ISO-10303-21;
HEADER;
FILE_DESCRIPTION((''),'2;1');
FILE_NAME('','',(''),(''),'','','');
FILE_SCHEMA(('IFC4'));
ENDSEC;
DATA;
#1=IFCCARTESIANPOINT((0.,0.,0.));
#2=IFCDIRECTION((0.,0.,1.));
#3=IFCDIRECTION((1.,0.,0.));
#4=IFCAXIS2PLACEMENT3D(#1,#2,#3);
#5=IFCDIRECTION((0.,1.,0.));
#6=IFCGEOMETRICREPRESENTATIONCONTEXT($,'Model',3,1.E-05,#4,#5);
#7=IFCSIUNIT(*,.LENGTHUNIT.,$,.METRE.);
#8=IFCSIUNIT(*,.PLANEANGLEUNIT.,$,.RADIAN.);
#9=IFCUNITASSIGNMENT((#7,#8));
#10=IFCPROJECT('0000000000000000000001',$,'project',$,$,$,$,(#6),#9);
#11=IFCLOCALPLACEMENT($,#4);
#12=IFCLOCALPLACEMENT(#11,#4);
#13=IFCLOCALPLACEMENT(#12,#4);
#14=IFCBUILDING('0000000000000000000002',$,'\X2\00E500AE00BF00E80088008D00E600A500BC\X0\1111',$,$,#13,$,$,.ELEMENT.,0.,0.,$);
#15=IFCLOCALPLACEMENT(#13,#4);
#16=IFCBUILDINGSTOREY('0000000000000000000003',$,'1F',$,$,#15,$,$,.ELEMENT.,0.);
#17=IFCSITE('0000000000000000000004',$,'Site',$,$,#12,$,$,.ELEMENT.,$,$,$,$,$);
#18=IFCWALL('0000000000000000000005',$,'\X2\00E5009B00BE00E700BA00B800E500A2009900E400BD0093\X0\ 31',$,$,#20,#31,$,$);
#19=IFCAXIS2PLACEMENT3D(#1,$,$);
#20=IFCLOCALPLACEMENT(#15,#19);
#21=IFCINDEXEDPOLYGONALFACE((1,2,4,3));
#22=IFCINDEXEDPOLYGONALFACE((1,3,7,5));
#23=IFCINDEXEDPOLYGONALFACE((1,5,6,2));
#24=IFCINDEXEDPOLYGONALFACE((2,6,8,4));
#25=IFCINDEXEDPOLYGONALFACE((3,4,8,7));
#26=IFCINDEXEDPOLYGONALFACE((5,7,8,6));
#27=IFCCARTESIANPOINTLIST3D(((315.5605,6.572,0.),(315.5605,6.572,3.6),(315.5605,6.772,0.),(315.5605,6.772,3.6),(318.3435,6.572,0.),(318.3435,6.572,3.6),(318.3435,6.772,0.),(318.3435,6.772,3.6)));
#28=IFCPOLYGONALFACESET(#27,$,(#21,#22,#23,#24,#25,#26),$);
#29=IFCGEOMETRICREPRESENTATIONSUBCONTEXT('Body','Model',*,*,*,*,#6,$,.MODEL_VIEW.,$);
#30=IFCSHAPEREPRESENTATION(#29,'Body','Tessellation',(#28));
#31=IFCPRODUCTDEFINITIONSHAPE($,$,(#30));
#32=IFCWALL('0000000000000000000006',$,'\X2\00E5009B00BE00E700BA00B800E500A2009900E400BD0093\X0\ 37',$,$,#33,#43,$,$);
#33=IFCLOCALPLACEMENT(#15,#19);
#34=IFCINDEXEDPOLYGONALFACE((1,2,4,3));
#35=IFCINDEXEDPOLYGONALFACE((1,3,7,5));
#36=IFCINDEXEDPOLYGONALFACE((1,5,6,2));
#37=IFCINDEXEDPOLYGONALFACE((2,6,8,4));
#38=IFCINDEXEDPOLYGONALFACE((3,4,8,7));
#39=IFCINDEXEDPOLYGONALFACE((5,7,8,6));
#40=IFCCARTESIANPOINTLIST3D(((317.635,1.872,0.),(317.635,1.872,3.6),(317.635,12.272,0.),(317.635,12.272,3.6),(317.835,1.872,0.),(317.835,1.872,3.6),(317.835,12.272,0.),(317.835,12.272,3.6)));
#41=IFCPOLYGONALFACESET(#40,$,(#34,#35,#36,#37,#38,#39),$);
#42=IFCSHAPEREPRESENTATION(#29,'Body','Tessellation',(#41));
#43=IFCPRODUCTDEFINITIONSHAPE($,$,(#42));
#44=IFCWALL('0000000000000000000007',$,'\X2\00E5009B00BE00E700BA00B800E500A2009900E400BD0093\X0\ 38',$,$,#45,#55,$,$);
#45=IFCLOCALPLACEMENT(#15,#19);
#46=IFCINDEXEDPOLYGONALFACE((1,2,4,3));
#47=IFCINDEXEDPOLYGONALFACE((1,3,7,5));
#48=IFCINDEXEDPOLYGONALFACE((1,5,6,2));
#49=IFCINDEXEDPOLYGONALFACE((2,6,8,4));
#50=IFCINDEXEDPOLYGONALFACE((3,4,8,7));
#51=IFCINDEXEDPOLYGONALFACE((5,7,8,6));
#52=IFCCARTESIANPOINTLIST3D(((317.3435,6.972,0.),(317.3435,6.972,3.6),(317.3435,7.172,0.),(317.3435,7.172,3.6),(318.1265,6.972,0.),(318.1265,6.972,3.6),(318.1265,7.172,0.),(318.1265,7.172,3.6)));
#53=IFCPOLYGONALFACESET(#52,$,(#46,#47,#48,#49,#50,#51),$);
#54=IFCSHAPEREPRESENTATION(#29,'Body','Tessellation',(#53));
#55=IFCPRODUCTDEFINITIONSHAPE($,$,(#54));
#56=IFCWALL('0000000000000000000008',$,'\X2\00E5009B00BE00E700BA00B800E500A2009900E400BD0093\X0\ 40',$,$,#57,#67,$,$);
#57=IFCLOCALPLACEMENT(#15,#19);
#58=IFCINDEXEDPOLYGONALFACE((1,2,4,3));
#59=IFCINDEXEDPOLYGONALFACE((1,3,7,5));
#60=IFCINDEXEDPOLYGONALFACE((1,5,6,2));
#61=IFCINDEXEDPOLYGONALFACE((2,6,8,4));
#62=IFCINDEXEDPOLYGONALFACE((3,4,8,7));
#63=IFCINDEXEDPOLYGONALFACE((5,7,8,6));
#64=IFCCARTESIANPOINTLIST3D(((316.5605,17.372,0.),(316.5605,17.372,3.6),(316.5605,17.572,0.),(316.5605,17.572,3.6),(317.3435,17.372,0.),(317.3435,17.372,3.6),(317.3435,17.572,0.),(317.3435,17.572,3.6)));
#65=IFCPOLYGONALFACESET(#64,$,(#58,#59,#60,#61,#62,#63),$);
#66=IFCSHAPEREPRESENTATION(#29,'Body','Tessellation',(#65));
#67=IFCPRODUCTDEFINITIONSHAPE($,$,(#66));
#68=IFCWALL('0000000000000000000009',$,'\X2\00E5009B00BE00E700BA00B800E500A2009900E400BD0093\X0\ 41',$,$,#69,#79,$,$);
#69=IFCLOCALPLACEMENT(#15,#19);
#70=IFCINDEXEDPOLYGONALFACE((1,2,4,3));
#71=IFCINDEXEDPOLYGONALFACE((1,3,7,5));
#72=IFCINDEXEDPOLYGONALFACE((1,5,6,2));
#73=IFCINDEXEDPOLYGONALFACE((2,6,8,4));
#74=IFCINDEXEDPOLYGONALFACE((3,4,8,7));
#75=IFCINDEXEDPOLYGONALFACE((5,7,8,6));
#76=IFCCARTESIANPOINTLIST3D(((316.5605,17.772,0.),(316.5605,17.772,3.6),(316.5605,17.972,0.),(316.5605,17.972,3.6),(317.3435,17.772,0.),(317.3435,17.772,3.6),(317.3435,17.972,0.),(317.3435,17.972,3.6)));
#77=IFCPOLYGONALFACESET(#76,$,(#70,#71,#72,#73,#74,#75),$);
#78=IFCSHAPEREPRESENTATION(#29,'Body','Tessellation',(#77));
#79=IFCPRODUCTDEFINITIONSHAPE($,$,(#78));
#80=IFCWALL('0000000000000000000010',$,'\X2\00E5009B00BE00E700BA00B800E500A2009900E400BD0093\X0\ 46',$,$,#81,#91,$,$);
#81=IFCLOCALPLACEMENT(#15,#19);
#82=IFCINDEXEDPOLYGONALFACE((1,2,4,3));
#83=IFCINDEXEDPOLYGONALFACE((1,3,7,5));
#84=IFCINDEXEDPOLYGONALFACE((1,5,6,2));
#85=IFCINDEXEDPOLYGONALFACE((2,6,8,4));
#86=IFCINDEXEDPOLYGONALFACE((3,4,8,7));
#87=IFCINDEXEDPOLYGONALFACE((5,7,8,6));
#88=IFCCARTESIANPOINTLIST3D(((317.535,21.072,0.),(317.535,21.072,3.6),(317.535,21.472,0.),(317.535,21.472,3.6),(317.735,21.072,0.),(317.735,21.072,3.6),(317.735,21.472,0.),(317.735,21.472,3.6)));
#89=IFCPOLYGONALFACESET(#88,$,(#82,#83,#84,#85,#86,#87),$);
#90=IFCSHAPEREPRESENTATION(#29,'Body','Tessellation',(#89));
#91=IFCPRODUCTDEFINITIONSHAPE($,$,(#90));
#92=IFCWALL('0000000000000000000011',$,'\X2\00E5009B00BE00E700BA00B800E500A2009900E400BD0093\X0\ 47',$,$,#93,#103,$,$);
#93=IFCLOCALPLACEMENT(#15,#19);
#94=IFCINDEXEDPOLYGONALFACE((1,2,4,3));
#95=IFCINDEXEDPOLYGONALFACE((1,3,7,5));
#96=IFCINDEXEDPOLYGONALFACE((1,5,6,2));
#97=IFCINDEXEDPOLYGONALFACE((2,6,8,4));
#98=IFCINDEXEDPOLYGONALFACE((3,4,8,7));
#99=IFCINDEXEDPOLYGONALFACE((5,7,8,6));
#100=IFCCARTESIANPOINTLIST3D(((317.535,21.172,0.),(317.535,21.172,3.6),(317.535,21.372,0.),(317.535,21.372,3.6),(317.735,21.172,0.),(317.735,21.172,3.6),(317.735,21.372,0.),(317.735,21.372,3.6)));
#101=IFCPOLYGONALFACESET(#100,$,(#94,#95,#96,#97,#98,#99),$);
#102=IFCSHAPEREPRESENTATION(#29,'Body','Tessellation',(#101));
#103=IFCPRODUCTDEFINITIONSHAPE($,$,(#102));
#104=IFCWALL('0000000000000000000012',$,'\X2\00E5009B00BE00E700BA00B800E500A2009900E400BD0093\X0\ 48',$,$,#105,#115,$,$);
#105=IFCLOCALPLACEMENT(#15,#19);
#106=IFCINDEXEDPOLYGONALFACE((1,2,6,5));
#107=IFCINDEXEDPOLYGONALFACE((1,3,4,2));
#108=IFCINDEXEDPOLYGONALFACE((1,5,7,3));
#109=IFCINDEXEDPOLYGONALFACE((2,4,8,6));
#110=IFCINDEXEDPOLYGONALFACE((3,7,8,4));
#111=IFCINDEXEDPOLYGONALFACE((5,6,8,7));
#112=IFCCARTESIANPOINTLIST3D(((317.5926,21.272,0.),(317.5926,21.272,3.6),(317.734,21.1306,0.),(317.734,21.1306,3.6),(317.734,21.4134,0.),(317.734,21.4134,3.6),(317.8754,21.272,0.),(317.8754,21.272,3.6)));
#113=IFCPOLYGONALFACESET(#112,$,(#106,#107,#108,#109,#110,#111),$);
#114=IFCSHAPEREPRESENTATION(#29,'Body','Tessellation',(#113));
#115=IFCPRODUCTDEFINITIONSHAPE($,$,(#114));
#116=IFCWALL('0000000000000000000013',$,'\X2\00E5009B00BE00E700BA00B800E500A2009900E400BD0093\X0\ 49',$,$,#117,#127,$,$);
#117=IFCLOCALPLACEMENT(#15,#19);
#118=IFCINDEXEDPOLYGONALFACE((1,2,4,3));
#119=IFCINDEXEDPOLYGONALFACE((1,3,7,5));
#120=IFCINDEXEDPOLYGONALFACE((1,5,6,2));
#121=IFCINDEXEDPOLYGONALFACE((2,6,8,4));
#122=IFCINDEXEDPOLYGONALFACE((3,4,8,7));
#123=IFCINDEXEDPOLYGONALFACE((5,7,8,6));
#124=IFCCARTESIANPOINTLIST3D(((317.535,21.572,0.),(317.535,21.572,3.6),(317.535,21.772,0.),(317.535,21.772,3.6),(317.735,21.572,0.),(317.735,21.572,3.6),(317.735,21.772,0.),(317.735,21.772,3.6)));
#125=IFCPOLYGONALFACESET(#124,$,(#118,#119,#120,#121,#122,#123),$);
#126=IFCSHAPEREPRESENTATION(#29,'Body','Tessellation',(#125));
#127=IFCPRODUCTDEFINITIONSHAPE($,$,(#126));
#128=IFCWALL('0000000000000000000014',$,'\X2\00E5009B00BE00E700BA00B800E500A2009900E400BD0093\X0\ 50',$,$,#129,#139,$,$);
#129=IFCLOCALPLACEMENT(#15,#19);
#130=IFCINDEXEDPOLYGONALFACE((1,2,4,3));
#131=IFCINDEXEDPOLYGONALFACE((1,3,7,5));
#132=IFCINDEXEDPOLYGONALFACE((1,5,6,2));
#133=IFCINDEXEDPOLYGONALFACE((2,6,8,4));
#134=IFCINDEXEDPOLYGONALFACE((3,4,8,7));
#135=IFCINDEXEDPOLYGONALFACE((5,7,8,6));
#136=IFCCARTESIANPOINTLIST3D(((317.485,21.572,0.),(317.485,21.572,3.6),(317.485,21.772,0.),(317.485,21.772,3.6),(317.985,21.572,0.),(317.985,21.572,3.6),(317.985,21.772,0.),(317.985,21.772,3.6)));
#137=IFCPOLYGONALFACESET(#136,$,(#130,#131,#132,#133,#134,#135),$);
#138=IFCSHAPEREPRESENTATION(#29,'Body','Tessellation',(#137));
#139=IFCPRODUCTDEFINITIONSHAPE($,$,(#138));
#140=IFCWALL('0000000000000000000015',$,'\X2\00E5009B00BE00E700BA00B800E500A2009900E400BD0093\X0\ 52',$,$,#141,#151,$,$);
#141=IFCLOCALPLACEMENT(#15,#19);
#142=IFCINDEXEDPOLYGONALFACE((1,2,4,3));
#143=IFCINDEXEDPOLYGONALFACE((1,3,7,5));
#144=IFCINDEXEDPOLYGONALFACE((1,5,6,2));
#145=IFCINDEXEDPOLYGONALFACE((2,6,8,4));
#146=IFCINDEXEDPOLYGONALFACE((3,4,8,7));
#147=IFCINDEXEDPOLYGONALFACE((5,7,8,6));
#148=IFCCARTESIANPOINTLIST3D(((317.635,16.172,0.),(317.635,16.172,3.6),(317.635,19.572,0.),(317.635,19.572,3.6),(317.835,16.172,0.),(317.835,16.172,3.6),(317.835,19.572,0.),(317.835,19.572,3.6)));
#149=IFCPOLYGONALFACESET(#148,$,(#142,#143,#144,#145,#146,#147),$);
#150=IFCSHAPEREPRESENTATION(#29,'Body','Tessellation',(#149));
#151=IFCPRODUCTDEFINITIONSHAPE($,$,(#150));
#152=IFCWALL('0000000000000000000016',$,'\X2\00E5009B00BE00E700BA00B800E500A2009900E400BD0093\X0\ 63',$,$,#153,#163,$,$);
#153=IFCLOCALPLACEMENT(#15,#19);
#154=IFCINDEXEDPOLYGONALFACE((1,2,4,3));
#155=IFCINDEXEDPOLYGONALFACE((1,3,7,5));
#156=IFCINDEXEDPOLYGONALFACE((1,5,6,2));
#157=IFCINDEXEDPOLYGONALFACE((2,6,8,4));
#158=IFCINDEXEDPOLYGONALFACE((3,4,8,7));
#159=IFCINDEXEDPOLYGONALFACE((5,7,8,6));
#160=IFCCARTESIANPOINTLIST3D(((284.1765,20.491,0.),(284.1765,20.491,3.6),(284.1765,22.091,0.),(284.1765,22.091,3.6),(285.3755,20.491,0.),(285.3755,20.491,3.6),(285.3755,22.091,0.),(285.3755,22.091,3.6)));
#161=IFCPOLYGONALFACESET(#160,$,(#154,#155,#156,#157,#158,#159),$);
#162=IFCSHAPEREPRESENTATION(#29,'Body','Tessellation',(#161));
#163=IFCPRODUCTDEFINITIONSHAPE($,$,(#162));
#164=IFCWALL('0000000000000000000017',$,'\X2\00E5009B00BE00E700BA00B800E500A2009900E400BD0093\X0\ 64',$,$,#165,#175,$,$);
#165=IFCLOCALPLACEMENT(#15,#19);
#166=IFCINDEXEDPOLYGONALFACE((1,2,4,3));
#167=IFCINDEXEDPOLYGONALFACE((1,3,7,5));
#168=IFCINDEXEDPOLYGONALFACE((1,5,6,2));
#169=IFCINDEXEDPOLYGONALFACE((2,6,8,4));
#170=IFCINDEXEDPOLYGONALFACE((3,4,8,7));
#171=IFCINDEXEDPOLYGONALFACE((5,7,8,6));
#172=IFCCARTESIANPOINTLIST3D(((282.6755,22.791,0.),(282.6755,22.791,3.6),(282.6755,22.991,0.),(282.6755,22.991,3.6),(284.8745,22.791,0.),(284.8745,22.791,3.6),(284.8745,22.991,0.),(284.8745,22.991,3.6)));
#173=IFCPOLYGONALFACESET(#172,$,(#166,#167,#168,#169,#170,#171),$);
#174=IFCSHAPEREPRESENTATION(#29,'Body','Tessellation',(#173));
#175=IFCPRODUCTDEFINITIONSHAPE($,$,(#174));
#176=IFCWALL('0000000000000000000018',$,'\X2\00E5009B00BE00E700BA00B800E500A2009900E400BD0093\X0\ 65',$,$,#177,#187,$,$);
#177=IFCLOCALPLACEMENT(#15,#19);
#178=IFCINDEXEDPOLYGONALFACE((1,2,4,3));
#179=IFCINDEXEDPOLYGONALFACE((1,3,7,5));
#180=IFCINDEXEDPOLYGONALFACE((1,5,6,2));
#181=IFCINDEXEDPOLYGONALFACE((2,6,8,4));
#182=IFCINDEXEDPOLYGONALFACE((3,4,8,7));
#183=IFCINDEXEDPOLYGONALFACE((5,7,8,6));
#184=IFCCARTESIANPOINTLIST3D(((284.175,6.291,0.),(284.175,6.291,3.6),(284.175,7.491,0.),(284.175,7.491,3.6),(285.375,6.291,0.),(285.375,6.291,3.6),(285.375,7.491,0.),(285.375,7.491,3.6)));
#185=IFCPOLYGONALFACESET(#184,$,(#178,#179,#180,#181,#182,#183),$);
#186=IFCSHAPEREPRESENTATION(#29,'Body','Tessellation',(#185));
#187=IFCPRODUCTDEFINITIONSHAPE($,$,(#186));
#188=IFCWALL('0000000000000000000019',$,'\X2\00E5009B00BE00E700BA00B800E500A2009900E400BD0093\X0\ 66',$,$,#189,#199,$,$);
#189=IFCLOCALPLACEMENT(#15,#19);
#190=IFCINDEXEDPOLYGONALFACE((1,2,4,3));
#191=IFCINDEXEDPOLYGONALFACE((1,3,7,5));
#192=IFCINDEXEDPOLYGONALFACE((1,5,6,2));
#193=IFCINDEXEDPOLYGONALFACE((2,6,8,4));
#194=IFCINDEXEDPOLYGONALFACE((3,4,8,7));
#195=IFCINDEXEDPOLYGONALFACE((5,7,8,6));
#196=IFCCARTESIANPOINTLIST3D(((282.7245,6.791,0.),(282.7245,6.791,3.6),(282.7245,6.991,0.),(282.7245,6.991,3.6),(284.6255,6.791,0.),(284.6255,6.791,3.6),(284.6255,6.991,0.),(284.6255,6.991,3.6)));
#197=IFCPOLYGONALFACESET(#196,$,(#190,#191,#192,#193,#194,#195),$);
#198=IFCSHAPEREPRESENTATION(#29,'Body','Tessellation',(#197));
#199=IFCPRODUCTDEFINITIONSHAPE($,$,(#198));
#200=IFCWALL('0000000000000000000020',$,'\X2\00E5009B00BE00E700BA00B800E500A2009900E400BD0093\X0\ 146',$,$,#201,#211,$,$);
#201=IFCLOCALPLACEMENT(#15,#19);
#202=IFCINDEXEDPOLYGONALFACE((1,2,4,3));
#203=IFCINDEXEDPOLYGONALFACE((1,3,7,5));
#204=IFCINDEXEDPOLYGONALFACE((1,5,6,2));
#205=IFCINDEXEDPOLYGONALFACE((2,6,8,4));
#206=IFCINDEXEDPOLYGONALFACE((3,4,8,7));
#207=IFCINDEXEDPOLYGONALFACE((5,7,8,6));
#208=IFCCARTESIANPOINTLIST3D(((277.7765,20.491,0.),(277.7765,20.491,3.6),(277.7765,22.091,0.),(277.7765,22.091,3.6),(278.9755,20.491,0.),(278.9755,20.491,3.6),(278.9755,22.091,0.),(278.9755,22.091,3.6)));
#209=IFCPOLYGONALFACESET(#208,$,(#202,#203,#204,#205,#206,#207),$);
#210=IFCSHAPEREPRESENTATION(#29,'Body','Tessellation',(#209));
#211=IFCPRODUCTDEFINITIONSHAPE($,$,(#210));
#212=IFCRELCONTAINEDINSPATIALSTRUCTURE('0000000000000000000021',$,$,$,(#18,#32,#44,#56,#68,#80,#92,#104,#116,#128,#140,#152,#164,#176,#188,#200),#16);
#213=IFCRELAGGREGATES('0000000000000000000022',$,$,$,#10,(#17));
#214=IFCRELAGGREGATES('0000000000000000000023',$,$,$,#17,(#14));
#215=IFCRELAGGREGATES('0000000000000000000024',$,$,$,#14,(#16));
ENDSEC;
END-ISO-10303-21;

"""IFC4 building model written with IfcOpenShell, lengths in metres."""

from ifc_helpers import new_model, si_unit, direction, frame, frame_2d, origin_with_axes, place, context, subcontext, project, spatial, rectangle, extrude, element, save


model = new_model("IFC4")

# Units and contexts
model_context = context("Model", 3, precision=1e-05, world=origin_with_axes(), true_north=direction((0.0, 1.0, 0.0)))
body_context = subcontext(model_context, "Body", "Model", "MODEL_VIEW")
ifc_project = project(units=[si_unit("LENGTHUNIT", "METRE"), si_unit("PLANEANGLEUNIT", "RADIAN")], contexts=[model_context])

# Site, building, storey
placement = place(None, origin_with_axes())
site_placement = place(placement, origin_with_axes())
site = spatial("IfcSite", under=ifc_project, at=site_placement, Name="Site", CompositionType="ELEMENT")
building_placement = place(site_placement, origin_with_axes())
building = spatial("IfcBuilding", under=site, at=building_placement, Name="å®¿è\u0088\u008dæ¥¼1111", CompositionType="ELEMENT", ElevationOfRefHeight=0.0, ElevationOfTerrain=0.0)
storey_placement = place(building_placement, origin_with_axes())
storey = spatial("IfcBuildingStorey", under=building, at=storey_placement, Name="1F", CompositionType="ELEMENT", Elevation=0.0)

# Walls
wall_1_placement = place(storey_placement, frame((316.952, 6.672, 0.0), z_axis=(0.0, 0.0, 1.0), x_axis=(1.0, 0.0, 0.0)))
element("IfcWall", 1, at=wall_1_placement, inside=storey, Name="å\u009b¾çº¸å¢\u0099ä½\u0093 31", context=body_context, shape_type="SweptSolid", body=[
    extrude(rectangle(XDim=2.783, YDim=0.2, at=frame_2d((0.0, 0.0), x_axis=(1.0, 0.0, 0.0))), frame((0.0, 0.0, 0.0), z_axis=(0.0, 0.0, 1.0)), (0.0, 0.0, 1.0), 3.6),
])
wall_2_placement = place(storey_placement, frame((317.735, 7.072, 0.0), z_axis=(0.0, 0.0, 1.0), x_axis=(0.0, 1.0, 0.0)))
element("IfcWall", 2, at=wall_2_placement, inside=storey, Name="å\u009b¾çº¸å¢\u0099ä½\u0093 37", context=body_context, shape_type="SweptSolid", body=[
    extrude(rectangle(XDim=10.4, YDim=0.2, at=frame_2d((0.0, 0.0), x_axis=(1.0, 0.0, 0.0))), frame((0.0, 0.0, 0.0), z_axis=(0.0, 0.0, 1.0)), (0.0, 0.0, 1.0), 3.6),
])
for number, where, z_axis, x_axis, name in (
    (3, (317.735, 7.072, 0.0), (0.0, 0.0, 1.0), (-1.0, 0.0, 0.0), "å\u009b¾çº¸å¢\u0099ä½\u0093 38"),
    (4, (316.952, 17.472, 0.0), (0.0, 0.0, 1.0), (1.0, 0.0, 0.0), "å\u009b¾çº¸å¢\u0099ä½\u0093 40"),
    (5, (316.952, 17.872, 0.0), (0.0, 0.0, 1.0), (1.0, 0.0, 0.0), "å\u009b¾çº¸å¢\u0099ä½\u0093 41"),
):
    element("IfcWall", number, at=place(storey_placement, frame(where, z_axis=z_axis, x_axis=x_axis)), inside=storey, Name=name, context=body_context, shape_type="SweptSolid", body=[
        extrude(rectangle(XDim=0.783, YDim=0.2, at=frame_2d((0.0, 0.0), x_axis=(1.0, 0.0, 0.0))), frame((0.0, 0.0, 0.0), z_axis=(0.0, 0.0, 1.0)), (0.0, 0.0, 1.0), 3.6),
    ])
wall_3_placement = place(storey_placement, frame((317.635, 21.272, 0.0), z_axis=(0.0, 0.0, 1.0), x_axis=(0.0, 1.0, 0.0)))
element("IfcWall", 6, at=wall_3_placement, inside=storey, Name="å\u009b¾çº¸å¢\u0099ä½\u0093 46", context=body_context, shape_type="SweptSolid", body=[
    extrude(rectangle(XDim=0.4, YDim=0.2, at=frame_2d((0.0, 0.0), x_axis=(1.0, 0.0, 0.0))), frame((0.0, 0.0, 0.0), z_axis=(0.0, 0.0, 1.0)), (0.0, 0.0, 1.0), 3.6),
])
for number, where, z_axis, x_axis, name in (
    (7, (317.635, 21.272, 0.0), (0.0, 0.0, 1.0), (1.0, 0.0, 0.0), "å\u009b¾çº¸å¢\u0099ä½\u0093 47"),
    (8, (317.734, 21.272, 0.0), (0.0, 0.0, 1.0), (0.707107, -0.707107, 0.0), "å\u009b¾çº¸å¢\u0099ä½\u0093 48"),
    (9, (317.635, 21.672, 0.0), (0.0, 0.0, 1.0), (1.0, 0.0, 0.0), "å\u009b¾çº¸å¢\u0099ä½\u0093 49"),
):
    element("IfcWall", number, at=place(storey_placement, frame(where, z_axis=z_axis, x_axis=x_axis)), inside=storey, Name=name, context=body_context, shape_type="SweptSolid", body=[
        extrude(rectangle(XDim=0.2, YDim=0.2, at=frame_2d((0.0, 0.0), x_axis=(1.0, 0.0, 0.0))), frame((0.0, 0.0, 0.0), z_axis=(0.0, 0.0, 1.0)), (0.0, 0.0, 1.0), 3.6),
    ])
wall_4_placement = place(storey_placement, frame((317.735, 21.672, 0.0), z_axis=(0.0, 0.0, 1.0), x_axis=(1.0, 0.0, 0.0)))
element("IfcWall", 10, at=wall_4_placement, inside=storey, Name="å\u009b¾çº¸å¢\u0099ä½\u0093 50", context=body_context, shape_type="SweptSolid", body=[
    extrude(rectangle(XDim=0.5, YDim=0.2, at=frame_2d((0.0, 0.0), x_axis=(1.0, 0.0, 0.0))), frame((0.0, 0.0, 0.0), z_axis=(0.0, 0.0, 1.0)), (0.0, 0.0, 1.0), 3.6),
])
wall_5_placement = place(storey_placement, frame((317.735, 17.872, 0.0), z_axis=(0.0, 0.0, 1.0), x_axis=(0.0, 1.0, 0.0)))
element("IfcWall", 11, at=wall_5_placement, inside=storey, Name="å\u009b¾çº¸å¢\u0099ä½\u0093 52", context=body_context, shape_type="SweptSolid", body=[
    extrude(rectangle(XDim=3.4, YDim=0.2, at=frame_2d((0.0, 0.0), x_axis=(1.0, 0.0, 0.0))), frame((0.0, 0.0, 0.0), z_axis=(0.0, 0.0, 1.0)), (0.0, 0.0, 1.0), 3.6),
])
wall_6_placement = place(storey_placement, frame((284.776, 21.291, 0.0), z_axis=(0.0, 0.0, 1.0), x_axis=(1.0, 0.0, 0.0)))
element("IfcWall", 12, at=wall_6_placement, inside=storey, Name="å\u009b¾çº¸å¢\u0099ä½\u0093 63", context=body_context, shape_type="SweptSolid", body=[
    extrude(rectangle(XDim=1.199, YDim=1.6, at=frame_2d((0.0, 0.0), x_axis=(1.0, 0.0, 0.0))), frame((0.0, 0.0, 0.0), z_axis=(0.0, 0.0, 1.0)), (0.0, 0.0, 1.0), 3.6),
])
wall_7_placement = place(storey_placement, frame((283.775, 22.891, 0.0), z_axis=(0.0, 0.0, 1.0), x_axis=(1.0, 0.0, 0.0)))
element("IfcWall", 13, at=wall_7_placement, inside=storey, Name="å\u009b¾çº¸å¢\u0099ä½\u0093 64", context=body_context, shape_type="SweptSolid", body=[
    extrude(rectangle(XDim=2.199, YDim=0.2, at=frame_2d((0.0, 0.0), x_axis=(1.0, 0.0, 0.0))), frame((0.0, 0.0, 0.0), z_axis=(0.0, 0.0, 1.0)), (0.0, 0.0, 1.0), 3.6),
])
wall_8_placement = place(storey_placement, frame((284.775, 6.891, 0.0), z_axis=(0.0, 0.0, 1.0), x_axis=(1.0, 0.0, 0.0)))
element("IfcWall", 14, at=wall_8_placement, inside=storey, Name="å\u009b¾çº¸å¢\u0099ä½\u0093 65", context=body_context, shape_type="SweptSolid", body=[
    extrude(rectangle(XDim=1.2, YDim=1.2, at=frame_2d((0.0, 0.0), x_axis=(1.0, 0.0, 0.0))), frame((0.0, 0.0, 0.0), z_axis=(0.0, 0.0, 1.0)), (0.0, 0.0, 1.0), 3.6),
])
wall_9_placement = place(storey_placement, frame((283.675, 6.891, 0.0), z_axis=(0.0, 0.0, 1.0), x_axis=(1.0, 0.0, 0.0)))
element("IfcWall", 15, at=wall_9_placement, inside=storey, Name="å\u009b¾çº¸å¢\u0099ä½\u0093 66", context=body_context, shape_type="SweptSolid", body=[
    extrude(rectangle(XDim=1.901, YDim=0.2, at=frame_2d((0.0, 0.0), x_axis=(1.0, 0.0, 0.0))), frame((0.0, 0.0, 0.0), z_axis=(0.0, 0.0, 1.0)), (0.0, 0.0, 1.0), 3.6),
])
wall_10_placement = place(storey_placement, frame((278.376, 21.291, 0.0), z_axis=(0.0, 0.0, 1.0), x_axis=(1.0, 0.0, 0.0)))
element("IfcWall", 16, at=wall_10_placement, inside=storey, Name="å\u009b¾çº¸å¢\u0099ä½\u0093 146", context=body_context, shape_type="SweptSolid", body=[
    extrude(rectangle(XDim=1.199, YDim=1.6, at=frame_2d((0.0, 0.0), x_axis=(1.0, 0.0, 0.0))), frame((0.0, 0.0, 0.0), z_axis=(0.0, 0.0, 1.0)), (0.0, 0.0, 1.0), 3.6),
])

save(model, "model.ifc")
